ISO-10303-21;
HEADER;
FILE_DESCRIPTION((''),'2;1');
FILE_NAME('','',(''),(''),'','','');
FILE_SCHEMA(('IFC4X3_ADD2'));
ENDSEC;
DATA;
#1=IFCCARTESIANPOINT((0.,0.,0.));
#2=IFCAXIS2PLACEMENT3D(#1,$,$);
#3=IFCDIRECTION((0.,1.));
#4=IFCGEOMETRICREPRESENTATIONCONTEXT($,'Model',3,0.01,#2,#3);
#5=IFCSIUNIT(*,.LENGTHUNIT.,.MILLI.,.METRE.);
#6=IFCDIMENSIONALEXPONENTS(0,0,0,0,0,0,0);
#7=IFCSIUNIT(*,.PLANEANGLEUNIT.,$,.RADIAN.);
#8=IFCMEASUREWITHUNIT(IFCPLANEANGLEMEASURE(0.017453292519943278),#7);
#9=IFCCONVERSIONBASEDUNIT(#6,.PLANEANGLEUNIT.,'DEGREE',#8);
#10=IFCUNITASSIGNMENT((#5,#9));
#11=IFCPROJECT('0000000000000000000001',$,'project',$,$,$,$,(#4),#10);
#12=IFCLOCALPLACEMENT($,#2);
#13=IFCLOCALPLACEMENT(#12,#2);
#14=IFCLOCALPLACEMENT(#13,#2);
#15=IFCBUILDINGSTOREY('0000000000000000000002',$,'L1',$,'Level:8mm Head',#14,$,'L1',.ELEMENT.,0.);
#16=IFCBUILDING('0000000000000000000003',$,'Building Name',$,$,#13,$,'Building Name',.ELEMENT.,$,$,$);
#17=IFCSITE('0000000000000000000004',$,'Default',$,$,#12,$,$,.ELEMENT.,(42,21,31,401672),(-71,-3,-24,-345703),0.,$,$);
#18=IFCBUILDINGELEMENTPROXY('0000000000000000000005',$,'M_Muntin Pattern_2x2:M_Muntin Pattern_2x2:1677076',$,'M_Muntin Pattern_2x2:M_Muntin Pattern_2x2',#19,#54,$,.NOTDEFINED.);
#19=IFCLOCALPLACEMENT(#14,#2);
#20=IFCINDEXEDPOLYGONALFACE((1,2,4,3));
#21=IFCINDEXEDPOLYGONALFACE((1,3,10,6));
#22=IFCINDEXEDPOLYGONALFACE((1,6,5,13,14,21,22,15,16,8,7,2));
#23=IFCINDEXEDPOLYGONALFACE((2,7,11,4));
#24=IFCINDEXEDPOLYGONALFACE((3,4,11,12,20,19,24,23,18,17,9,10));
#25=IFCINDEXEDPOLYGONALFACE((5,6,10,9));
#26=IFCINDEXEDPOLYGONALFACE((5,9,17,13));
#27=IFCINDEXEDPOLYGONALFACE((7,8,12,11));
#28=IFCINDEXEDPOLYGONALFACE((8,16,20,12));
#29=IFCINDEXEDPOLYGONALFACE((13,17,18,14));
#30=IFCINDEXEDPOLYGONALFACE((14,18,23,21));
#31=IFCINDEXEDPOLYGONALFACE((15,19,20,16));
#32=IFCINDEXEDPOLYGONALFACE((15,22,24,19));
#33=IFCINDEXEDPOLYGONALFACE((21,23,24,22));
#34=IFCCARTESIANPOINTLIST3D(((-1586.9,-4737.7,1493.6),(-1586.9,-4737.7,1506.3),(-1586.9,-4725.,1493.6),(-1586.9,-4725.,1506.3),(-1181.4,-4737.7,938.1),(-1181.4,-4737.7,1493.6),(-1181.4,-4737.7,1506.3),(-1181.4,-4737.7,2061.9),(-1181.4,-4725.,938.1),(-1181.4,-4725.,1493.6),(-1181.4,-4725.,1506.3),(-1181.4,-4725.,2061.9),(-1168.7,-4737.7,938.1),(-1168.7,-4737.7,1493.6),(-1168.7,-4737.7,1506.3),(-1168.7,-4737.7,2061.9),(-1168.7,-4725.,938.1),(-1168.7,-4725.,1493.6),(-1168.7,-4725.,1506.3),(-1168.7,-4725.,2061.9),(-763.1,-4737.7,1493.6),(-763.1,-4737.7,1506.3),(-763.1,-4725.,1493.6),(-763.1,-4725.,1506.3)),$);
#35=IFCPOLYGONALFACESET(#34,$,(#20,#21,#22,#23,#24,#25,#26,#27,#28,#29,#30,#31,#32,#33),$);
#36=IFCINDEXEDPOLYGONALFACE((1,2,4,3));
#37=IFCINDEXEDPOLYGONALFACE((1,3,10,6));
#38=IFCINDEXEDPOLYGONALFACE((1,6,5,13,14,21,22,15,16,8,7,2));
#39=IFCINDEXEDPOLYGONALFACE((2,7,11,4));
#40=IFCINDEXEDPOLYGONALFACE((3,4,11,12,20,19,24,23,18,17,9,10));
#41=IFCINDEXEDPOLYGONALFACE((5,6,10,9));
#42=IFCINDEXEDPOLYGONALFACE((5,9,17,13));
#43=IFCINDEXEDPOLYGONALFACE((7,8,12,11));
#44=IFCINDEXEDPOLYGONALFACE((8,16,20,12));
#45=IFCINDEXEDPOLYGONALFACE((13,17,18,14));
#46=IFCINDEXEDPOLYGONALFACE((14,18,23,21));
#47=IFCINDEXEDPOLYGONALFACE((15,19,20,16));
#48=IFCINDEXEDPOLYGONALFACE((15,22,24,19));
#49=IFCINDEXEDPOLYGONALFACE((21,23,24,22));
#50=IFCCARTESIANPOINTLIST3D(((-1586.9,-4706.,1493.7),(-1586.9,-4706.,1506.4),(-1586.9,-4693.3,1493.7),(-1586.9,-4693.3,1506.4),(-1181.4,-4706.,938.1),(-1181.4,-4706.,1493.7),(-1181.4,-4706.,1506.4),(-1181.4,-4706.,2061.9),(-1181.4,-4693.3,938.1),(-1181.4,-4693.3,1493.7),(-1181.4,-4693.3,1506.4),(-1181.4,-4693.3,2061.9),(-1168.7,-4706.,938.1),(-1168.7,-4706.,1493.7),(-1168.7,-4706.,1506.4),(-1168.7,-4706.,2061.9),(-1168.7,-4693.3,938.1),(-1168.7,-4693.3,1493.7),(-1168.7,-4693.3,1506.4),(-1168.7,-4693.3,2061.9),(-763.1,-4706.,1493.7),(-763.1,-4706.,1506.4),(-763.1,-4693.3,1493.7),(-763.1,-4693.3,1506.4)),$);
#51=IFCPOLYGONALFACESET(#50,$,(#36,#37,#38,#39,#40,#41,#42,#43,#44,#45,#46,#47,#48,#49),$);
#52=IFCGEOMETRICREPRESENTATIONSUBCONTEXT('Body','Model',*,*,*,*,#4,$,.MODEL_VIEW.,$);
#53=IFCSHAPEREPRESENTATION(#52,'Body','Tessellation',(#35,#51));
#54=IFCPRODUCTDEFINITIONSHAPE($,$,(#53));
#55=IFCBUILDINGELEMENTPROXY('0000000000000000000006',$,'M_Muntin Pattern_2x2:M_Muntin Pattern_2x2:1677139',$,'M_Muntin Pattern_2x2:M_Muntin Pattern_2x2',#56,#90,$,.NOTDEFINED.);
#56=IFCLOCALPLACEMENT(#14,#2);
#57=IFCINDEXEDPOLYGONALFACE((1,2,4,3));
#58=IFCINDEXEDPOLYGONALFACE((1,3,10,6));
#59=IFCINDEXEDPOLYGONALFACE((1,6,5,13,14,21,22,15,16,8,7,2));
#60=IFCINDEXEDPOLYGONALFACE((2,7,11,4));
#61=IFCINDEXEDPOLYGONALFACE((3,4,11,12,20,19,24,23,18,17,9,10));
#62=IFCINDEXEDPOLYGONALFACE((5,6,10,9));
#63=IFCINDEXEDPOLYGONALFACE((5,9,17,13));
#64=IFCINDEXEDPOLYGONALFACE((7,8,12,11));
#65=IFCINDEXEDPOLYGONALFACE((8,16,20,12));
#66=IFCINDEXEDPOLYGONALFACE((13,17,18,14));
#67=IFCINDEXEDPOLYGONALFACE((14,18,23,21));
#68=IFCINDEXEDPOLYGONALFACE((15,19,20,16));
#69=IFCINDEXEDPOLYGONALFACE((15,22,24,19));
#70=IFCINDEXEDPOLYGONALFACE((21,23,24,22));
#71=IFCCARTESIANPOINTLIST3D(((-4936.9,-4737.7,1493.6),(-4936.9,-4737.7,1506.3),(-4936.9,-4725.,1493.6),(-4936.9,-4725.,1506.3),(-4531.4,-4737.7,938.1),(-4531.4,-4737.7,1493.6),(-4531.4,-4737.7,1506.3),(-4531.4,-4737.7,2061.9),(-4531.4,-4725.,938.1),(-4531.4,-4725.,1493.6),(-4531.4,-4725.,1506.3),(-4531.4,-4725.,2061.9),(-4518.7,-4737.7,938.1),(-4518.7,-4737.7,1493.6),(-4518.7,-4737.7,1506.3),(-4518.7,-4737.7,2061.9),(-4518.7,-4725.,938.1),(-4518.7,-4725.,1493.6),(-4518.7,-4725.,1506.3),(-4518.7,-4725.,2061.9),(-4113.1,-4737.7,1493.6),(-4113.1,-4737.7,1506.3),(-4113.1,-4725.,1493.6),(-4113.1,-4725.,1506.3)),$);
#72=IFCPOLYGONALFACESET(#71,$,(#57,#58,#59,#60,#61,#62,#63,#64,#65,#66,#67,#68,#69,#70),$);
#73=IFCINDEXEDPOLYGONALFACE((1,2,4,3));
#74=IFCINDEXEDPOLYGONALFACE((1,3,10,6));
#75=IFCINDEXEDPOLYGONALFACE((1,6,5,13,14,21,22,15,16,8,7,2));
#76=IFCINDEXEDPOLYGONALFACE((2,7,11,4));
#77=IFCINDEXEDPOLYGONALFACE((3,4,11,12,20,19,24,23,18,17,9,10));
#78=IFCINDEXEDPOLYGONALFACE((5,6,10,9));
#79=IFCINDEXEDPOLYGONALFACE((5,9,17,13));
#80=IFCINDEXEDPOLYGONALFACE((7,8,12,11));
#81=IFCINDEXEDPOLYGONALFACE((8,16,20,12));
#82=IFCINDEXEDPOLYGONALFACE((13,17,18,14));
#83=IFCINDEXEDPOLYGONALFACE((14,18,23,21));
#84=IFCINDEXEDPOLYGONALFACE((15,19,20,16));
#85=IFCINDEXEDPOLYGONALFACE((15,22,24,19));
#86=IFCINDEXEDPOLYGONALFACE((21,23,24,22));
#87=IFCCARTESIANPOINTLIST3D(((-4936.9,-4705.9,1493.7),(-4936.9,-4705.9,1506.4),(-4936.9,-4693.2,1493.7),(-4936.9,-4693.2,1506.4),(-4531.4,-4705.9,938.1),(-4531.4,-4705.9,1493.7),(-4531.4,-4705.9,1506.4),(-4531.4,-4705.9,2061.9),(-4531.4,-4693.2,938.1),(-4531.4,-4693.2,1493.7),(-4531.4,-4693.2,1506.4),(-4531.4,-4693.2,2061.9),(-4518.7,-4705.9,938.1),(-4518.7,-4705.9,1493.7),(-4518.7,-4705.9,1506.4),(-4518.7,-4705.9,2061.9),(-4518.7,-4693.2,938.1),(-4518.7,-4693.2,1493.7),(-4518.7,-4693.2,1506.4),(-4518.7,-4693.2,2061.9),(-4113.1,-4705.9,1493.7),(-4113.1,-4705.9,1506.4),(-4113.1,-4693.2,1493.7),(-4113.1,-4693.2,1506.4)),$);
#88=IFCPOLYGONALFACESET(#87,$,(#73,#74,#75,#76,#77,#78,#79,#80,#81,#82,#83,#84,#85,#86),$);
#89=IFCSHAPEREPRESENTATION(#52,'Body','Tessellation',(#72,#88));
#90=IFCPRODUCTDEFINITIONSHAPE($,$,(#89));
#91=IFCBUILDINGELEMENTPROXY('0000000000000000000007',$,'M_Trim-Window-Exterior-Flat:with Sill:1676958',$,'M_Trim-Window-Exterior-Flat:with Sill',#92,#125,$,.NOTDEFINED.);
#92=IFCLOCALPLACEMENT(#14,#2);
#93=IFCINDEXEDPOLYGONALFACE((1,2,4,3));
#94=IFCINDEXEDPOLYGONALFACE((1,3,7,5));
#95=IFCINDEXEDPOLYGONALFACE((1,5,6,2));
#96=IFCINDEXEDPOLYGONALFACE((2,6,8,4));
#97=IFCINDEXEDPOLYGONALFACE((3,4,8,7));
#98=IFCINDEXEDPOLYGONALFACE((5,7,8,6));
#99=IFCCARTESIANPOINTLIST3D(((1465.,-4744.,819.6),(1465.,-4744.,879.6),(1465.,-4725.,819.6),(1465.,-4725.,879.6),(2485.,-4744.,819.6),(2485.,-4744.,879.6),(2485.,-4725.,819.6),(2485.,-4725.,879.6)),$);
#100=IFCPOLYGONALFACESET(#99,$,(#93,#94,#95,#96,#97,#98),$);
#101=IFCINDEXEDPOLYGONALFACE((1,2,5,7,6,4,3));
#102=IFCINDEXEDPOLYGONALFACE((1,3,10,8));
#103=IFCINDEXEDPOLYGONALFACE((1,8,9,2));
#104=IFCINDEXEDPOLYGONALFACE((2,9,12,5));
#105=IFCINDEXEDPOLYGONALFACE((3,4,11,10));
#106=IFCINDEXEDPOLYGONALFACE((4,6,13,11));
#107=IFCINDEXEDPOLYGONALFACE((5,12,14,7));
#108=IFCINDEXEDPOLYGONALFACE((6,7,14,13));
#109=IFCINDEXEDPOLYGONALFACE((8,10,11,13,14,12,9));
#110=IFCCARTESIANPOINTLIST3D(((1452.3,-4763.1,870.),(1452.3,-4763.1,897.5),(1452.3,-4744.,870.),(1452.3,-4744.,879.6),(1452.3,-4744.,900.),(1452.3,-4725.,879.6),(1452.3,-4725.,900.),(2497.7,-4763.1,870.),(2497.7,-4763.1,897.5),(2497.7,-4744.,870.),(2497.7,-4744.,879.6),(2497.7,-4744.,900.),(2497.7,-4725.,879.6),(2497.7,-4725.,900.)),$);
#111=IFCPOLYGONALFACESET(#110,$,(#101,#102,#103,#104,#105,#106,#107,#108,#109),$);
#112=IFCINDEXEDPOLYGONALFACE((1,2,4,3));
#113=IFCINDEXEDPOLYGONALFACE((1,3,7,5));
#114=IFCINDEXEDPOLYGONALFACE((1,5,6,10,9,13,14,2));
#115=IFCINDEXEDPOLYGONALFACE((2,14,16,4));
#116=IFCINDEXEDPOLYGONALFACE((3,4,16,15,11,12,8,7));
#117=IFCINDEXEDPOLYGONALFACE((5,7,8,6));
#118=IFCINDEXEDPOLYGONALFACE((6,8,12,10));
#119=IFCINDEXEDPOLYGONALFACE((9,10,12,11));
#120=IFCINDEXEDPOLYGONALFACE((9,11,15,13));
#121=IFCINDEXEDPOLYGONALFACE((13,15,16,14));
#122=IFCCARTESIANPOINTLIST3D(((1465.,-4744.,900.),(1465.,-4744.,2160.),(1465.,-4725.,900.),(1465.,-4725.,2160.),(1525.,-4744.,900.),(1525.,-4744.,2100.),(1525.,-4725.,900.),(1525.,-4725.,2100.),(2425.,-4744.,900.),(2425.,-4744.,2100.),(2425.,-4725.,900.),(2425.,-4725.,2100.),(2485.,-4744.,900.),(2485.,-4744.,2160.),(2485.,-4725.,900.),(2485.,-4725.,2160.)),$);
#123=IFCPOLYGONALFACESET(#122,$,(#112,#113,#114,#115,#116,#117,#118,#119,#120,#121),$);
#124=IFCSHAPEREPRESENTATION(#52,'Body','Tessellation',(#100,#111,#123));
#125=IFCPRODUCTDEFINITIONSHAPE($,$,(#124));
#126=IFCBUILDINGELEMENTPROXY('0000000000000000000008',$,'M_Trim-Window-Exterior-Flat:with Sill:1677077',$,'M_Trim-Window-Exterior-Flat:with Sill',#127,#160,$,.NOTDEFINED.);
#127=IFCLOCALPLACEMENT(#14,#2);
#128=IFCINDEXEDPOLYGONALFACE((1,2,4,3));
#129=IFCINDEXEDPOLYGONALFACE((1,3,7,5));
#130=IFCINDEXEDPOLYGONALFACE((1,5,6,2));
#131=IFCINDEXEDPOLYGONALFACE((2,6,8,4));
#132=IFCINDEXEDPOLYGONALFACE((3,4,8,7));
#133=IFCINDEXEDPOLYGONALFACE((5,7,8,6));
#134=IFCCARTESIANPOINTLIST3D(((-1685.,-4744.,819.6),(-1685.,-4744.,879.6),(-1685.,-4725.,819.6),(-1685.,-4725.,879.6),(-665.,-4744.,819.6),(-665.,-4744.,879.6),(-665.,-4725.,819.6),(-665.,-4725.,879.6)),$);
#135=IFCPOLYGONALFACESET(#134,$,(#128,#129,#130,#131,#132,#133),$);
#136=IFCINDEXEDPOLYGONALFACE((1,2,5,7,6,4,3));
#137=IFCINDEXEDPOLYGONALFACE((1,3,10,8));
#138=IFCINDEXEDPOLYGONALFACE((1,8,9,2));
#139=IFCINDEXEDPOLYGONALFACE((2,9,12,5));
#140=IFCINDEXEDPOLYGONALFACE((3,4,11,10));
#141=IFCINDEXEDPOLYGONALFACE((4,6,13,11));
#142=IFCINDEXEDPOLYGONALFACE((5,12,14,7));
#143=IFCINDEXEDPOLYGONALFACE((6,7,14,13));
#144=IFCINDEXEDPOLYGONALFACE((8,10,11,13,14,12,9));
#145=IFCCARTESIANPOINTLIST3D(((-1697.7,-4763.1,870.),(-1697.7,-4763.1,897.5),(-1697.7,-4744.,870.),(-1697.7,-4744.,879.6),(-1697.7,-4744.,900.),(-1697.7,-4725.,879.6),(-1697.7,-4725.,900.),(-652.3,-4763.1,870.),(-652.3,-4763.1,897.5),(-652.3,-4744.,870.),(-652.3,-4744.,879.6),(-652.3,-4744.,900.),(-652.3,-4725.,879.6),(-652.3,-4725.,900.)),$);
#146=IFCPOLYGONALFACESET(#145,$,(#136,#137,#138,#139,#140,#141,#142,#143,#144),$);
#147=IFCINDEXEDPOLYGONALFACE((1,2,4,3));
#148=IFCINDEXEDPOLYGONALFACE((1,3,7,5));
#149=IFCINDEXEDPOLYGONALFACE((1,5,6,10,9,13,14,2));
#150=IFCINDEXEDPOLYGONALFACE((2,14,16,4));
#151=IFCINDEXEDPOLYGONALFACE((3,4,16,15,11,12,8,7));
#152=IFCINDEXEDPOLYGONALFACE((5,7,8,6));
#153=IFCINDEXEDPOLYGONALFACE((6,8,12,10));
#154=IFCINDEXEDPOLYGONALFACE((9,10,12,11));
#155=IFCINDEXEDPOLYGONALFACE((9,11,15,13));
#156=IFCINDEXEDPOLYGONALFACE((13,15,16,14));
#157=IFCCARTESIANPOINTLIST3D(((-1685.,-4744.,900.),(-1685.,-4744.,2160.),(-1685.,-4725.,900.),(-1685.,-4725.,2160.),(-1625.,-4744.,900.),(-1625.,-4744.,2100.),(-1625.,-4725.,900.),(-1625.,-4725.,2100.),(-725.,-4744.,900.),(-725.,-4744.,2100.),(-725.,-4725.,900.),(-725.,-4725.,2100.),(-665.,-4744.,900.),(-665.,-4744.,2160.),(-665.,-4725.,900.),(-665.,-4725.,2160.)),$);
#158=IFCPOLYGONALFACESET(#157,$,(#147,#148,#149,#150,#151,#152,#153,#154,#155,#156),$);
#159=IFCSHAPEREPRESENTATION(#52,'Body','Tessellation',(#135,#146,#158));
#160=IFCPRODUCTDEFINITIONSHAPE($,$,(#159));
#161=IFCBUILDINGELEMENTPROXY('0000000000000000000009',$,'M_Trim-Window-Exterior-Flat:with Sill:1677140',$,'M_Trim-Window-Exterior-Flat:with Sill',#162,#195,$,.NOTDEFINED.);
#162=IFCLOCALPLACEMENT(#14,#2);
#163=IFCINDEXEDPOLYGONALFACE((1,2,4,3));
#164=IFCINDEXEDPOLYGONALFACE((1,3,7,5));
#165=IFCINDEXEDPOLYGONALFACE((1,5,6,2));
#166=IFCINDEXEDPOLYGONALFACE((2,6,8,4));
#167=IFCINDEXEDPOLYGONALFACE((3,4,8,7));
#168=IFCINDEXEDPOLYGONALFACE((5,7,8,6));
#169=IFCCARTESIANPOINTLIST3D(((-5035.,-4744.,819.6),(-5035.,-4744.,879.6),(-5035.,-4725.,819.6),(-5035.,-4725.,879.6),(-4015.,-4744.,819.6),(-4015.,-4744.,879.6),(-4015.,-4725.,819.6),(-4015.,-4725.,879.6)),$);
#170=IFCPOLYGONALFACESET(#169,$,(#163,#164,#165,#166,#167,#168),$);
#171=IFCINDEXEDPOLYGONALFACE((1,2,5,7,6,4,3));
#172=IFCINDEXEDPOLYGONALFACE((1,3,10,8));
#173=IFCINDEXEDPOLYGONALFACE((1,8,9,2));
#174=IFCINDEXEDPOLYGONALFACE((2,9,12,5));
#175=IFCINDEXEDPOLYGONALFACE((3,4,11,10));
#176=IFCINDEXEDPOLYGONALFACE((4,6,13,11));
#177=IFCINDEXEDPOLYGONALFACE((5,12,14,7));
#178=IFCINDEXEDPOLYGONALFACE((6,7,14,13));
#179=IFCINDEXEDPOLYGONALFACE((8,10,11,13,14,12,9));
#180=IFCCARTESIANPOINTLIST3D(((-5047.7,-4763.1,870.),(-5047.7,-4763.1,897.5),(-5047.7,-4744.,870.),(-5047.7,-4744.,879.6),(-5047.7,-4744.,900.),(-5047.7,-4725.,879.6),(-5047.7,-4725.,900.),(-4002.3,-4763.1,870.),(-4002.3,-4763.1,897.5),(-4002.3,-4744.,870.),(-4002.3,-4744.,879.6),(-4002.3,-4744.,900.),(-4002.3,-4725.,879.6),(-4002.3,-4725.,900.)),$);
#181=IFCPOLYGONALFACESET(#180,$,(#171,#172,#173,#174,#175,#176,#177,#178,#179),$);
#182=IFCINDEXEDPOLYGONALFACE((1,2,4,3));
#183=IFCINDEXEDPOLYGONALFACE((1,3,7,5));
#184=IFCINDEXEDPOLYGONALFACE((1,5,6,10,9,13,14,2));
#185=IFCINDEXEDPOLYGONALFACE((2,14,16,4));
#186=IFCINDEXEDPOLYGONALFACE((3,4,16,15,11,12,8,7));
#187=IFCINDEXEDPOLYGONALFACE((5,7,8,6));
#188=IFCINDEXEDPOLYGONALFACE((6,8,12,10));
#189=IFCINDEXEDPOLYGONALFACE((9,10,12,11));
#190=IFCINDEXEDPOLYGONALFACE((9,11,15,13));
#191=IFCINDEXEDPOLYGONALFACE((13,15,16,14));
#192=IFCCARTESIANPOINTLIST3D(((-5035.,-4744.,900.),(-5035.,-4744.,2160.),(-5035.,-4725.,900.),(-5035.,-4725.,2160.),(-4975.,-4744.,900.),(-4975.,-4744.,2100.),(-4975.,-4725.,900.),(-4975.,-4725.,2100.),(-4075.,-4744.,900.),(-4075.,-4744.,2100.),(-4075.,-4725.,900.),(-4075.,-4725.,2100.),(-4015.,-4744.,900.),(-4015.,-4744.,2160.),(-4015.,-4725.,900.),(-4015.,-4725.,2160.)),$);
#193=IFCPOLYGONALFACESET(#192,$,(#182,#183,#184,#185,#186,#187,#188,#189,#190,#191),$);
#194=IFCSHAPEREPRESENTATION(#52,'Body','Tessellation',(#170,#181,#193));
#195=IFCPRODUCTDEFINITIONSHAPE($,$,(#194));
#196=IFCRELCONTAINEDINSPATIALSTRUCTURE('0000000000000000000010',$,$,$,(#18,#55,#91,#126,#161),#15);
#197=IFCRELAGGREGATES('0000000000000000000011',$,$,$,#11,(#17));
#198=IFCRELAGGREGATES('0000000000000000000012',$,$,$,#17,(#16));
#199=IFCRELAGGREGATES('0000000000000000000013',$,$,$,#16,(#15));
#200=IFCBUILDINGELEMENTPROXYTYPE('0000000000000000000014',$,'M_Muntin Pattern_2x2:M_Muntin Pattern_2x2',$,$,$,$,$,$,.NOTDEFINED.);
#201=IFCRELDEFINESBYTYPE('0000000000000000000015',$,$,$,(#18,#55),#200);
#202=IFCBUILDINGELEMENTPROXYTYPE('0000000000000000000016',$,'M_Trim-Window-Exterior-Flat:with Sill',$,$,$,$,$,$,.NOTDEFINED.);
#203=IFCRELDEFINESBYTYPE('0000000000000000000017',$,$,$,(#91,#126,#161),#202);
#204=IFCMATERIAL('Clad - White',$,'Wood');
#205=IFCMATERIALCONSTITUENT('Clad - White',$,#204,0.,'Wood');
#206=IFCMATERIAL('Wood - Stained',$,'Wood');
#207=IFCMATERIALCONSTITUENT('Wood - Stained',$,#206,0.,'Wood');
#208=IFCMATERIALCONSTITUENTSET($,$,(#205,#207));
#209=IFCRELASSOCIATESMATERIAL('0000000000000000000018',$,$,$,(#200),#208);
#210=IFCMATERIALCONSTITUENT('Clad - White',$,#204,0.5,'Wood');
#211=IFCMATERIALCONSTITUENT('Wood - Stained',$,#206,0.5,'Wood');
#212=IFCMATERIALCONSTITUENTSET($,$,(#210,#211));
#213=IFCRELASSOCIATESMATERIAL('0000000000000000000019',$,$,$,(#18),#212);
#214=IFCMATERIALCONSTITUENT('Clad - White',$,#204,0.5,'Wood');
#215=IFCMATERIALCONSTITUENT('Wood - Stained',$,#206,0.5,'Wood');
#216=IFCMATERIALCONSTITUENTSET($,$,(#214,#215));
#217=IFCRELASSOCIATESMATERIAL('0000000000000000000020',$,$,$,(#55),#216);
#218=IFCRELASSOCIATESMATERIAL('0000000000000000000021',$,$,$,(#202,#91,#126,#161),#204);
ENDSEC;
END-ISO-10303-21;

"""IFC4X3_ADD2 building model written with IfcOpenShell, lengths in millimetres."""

from ifc_helpers import new_model, entity, si_unit, converted_unit, direction, frame, frame_2d, origin, place, context, subcontext, project, spatial, polyline, rectangle, outline, extrude, source, transform, mapped, material, constituent, constituent_set, type_object, type_shapes, element, save


model = new_model("IFC4X3_ADD2")

# Units and contexts
model_context = context("Model", 3, precision=0.01, world=origin(), true_north=direction((0.0, 1.0)))
body_context = subcontext(model_context, "Body", "Model", "MODEL_VIEW")
ifc_project = project(units=[si_unit("LENGTHUNIT", "METRE", prefix="MILLI"), converted_unit("PLANEANGLEUNIT", "DEGREE", entity("IfcPlaneAngleMeasure", 0.017453292519943278), si_unit("PLANEANGLEUNIT", "RADIAN"), dimensions=[0, 0, 0, 0, 0, 0, 0])], contexts=[model_context])

# Site, building, storey
site_placement = place(None, origin())
site = spatial("IfcSite", under=ifc_project, at=site_placement, Name="Default", CompositionType="ELEMENT", RefLatitude=(42, 21, 31, 401672), RefLongitude=(-71, -3, -24, -345703), RefElevation=0.0)
building_placement = place(site_placement, origin())
building = spatial("IfcBuilding", under=site, at=building_placement, Name="Building Name", LongName="Building Name", CompositionType="ELEMENT")
storey_placement = place(building_placement, origin())
storey = spatial("IfcBuildingStorey", under=building, at=storey_placement, Name="L1", ObjectType="Level:8mm Head", LongName="L1", CompositionType="ELEMENT", Elevation=0.0)

# Building element proxies
ifc_material_1 = material(Name="Clad - White", Category="Wood")
ifc_material_2 = material(Name="Wood - Stained", Category="Wood")
ifc_constituent_1 = constituent(ifc_material_1, Name="Clad - White", Category="Wood", fraction=0.0)
ifc_constituent_2 = constituent(ifc_material_2, Name="Wood - Stained", Category="Wood", fraction=0.0)
ifc_constituent_set_1 = constituent_set(constituents=[ifc_constituent_1, ifc_constituent_2])
building_element_proxy_type_1 = type_object("IfcBuildingElementProxyType", Name="M_Muntin Pattern_2x2:M_Muntin Pattern_2x2", PredefinedType="NOTDEFINED", material=ifc_constituent_set_1)
shared_shape_1 = source(origin(), body_context, "Body", "SweptSolid", [
    extrude(outline(polyline([(6.4, -6.4), (561.9, -6.4), (561.9, 6.3), (6.4, 6.3), (6.4, 411.9), (-6.3, 411.9), (-6.3, 6.3), (-561.9, 6.3), (-561.9, -6.4), (-6.3, -6.4), (-6.3, -411.9), (6.4, -411.9), (6.4, -6.4)])), frame((0.0, -22.2, 561.9), z_axis=(0.0, 1.0, 0.0), x_axis=(0.0, 0.0, 1.0)), (0.0, 0.0, 1.0), 12.7),
    extrude(outline(polyline([(6.4, -6.4), (561.9, -6.4), (561.9, 6.3), (6.4, 6.3), (6.4, 411.9), (-6.3, 411.9), (-6.3, 6.3), (-561.9, 6.3), (-561.9, -6.4), (-6.3, -6.4), (-6.3, -411.9), (6.4, -411.9), (6.4, -6.4)])), frame((0.0, 9.5, 561.9), z_axis=(0.0, 1.0, 0.0), x_axis=(0.0, 0.0, 1.0)), (0.0, 0.0, 1.0), 12.7),
])
type_shapes(building_element_proxy_type_1, [shared_shape_1])
ifc_constituent_3 = constituent(ifc_material_1, Name="Clad - White", Category="Wood", fraction=0.5)
ifc_constituent_4 = constituent(ifc_material_2, Name="Wood - Stained", Category="Wood", fraction=0.5)
ifc_constituent_set_2 = constituent_set(constituents=[ifc_constituent_3, ifc_constituent_4])
proxy_1_placement = place(storey_placement, frame((-1175.0, -4715.5, 938.1)))
element("IfcBuildingElementProxy", 1, at=proxy_1_placement, inside=storey, type_object=building_element_proxy_type_1, material=ifc_constituent_set_2, Name="M_Muntin Pattern_2x2:M_Muntin Pattern_2x2:1677076", ObjectType="M_Muntin Pattern_2x2:M_Muntin Pattern_2x2", PredefinedType="NOTDEFINED", context=body_context, shape_type="MappedRepresentation", body=[
    mapped(shared_shape_1, transform((0.0, 0.0, 0.0), scale=1.0)),
])
ifc_constituent_5 = constituent(ifc_material_1, Name="Clad - White", Category="Wood", fraction=0.5)
ifc_constituent_6 = constituent(ifc_material_2, Name="Wood - Stained", Category="Wood", fraction=0.5)
ifc_constituent_set_3 = constituent_set(constituents=[ifc_constituent_5, ifc_constituent_6])
proxy_2_placement = place(storey_placement, frame((-4525.0, -4715.5, 938.1)))
element("IfcBuildingElementProxy", 2, at=proxy_2_placement, inside=storey, type_object=building_element_proxy_type_1, material=ifc_constituent_set_3, Name="M_Muntin Pattern_2x2:M_Muntin Pattern_2x2:1677139", ObjectType="M_Muntin Pattern_2x2:M_Muntin Pattern_2x2", PredefinedType="NOTDEFINED", context=body_context, shape_type="MappedRepresentation", body=[
    mapped(shared_shape_1, transform((0.0, 0.0, 0.0), scale=1.0)),
])
building_element_proxy_type_2 = type_object("IfcBuildingElementProxyType", Name="M_Trim-Window-Exterior-Flat:with Sill", PredefinedType="NOTDEFINED", material=ifc_material_1)
shared_shape_2 = source(origin(), body_context, "Body", "SweptSolid", [
    extrude(rectangle(XDim=1020.0, YDim=60.0, at=frame_2d((0.0, 0.0), x_axis=(1.0, 0.0))), frame((0.0, -1250.4, 0.0), z_axis=(0.0, 0.0, 1.0), x_axis=(-1.0, 0.0, 0.0)), (0.0, 0.0, 1.0), 19.0),
    extrude(outline(polyline([(-19.0, -15.2), (0.0, -15.2), (0.0, -5.7), (19.0, -5.7), (19.0, 14.8), (0.0, 14.8), (-19.0, 12.3), (-19.0, -15.2)])), frame((-522.7, -1214.8, 19.0), z_axis=(1.0, 0.0, 0.0), x_axis=(0.0, 0.0, -1.0)), (0.0, 0.0, 1.0), 1045.4),
    extrude(outline(polyline([(-645.0, -510.0), (615.0, -510.0), (615.0, -450.0), (-585.0, -450.0), (-585.0, 450.0), (615.0, 450.0), (615.0, 510.0), (-645.0, 510.0), (-645.0, -510.0)])), frame((0.0, -585.0, 0.0), z_axis=(0.0, 0.0, 1.0), x_axis=(0.0, -1.0, 0.0)), (0.0, 0.0, 1.0), 19.0),
])
type_shapes(building_element_proxy_type_2, [shared_shape_2])
for number, where, z_axis, x_axis, name in (
    (3, (1975.0, -4725.0, 2100.0), (0.0, -1.0, 0.0), (1.0, 0.0, 0.0), "M_Trim-Window-Exterior-Flat:with Sill:1676958"),
    (4, (-1175.0, -4725.0, 2100.0), (0.0, -1.0, 0.0), (1.0, 0.0, 0.0), "M_Trim-Window-Exterior-Flat:with Sill:1677077"),
    (5, (-4525.0, -4725.0, 2100.0), (0.0, -1.0, 0.0), (1.0, 0.0, 0.0), "M_Trim-Window-Exterior-Flat:with Sill:1677140"),
):
    element("IfcBuildingElementProxy", number, at=place(storey_placement, frame(where, z_axis=z_axis, x_axis=x_axis)), inside=storey, type_object=building_element_proxy_type_2, material=ifc_material_1, Name=name, ObjectType="M_Trim-Window-Exterior-Flat:with Sill", PredefinedType="NOTDEFINED", context=body_context, shape_type="MappedRepresentation", body=[
        mapped(shared_shape_2, transform((0.0, 0.0, 0.0), scale=1.0)),
    ])

save(model, "model.ifc")
